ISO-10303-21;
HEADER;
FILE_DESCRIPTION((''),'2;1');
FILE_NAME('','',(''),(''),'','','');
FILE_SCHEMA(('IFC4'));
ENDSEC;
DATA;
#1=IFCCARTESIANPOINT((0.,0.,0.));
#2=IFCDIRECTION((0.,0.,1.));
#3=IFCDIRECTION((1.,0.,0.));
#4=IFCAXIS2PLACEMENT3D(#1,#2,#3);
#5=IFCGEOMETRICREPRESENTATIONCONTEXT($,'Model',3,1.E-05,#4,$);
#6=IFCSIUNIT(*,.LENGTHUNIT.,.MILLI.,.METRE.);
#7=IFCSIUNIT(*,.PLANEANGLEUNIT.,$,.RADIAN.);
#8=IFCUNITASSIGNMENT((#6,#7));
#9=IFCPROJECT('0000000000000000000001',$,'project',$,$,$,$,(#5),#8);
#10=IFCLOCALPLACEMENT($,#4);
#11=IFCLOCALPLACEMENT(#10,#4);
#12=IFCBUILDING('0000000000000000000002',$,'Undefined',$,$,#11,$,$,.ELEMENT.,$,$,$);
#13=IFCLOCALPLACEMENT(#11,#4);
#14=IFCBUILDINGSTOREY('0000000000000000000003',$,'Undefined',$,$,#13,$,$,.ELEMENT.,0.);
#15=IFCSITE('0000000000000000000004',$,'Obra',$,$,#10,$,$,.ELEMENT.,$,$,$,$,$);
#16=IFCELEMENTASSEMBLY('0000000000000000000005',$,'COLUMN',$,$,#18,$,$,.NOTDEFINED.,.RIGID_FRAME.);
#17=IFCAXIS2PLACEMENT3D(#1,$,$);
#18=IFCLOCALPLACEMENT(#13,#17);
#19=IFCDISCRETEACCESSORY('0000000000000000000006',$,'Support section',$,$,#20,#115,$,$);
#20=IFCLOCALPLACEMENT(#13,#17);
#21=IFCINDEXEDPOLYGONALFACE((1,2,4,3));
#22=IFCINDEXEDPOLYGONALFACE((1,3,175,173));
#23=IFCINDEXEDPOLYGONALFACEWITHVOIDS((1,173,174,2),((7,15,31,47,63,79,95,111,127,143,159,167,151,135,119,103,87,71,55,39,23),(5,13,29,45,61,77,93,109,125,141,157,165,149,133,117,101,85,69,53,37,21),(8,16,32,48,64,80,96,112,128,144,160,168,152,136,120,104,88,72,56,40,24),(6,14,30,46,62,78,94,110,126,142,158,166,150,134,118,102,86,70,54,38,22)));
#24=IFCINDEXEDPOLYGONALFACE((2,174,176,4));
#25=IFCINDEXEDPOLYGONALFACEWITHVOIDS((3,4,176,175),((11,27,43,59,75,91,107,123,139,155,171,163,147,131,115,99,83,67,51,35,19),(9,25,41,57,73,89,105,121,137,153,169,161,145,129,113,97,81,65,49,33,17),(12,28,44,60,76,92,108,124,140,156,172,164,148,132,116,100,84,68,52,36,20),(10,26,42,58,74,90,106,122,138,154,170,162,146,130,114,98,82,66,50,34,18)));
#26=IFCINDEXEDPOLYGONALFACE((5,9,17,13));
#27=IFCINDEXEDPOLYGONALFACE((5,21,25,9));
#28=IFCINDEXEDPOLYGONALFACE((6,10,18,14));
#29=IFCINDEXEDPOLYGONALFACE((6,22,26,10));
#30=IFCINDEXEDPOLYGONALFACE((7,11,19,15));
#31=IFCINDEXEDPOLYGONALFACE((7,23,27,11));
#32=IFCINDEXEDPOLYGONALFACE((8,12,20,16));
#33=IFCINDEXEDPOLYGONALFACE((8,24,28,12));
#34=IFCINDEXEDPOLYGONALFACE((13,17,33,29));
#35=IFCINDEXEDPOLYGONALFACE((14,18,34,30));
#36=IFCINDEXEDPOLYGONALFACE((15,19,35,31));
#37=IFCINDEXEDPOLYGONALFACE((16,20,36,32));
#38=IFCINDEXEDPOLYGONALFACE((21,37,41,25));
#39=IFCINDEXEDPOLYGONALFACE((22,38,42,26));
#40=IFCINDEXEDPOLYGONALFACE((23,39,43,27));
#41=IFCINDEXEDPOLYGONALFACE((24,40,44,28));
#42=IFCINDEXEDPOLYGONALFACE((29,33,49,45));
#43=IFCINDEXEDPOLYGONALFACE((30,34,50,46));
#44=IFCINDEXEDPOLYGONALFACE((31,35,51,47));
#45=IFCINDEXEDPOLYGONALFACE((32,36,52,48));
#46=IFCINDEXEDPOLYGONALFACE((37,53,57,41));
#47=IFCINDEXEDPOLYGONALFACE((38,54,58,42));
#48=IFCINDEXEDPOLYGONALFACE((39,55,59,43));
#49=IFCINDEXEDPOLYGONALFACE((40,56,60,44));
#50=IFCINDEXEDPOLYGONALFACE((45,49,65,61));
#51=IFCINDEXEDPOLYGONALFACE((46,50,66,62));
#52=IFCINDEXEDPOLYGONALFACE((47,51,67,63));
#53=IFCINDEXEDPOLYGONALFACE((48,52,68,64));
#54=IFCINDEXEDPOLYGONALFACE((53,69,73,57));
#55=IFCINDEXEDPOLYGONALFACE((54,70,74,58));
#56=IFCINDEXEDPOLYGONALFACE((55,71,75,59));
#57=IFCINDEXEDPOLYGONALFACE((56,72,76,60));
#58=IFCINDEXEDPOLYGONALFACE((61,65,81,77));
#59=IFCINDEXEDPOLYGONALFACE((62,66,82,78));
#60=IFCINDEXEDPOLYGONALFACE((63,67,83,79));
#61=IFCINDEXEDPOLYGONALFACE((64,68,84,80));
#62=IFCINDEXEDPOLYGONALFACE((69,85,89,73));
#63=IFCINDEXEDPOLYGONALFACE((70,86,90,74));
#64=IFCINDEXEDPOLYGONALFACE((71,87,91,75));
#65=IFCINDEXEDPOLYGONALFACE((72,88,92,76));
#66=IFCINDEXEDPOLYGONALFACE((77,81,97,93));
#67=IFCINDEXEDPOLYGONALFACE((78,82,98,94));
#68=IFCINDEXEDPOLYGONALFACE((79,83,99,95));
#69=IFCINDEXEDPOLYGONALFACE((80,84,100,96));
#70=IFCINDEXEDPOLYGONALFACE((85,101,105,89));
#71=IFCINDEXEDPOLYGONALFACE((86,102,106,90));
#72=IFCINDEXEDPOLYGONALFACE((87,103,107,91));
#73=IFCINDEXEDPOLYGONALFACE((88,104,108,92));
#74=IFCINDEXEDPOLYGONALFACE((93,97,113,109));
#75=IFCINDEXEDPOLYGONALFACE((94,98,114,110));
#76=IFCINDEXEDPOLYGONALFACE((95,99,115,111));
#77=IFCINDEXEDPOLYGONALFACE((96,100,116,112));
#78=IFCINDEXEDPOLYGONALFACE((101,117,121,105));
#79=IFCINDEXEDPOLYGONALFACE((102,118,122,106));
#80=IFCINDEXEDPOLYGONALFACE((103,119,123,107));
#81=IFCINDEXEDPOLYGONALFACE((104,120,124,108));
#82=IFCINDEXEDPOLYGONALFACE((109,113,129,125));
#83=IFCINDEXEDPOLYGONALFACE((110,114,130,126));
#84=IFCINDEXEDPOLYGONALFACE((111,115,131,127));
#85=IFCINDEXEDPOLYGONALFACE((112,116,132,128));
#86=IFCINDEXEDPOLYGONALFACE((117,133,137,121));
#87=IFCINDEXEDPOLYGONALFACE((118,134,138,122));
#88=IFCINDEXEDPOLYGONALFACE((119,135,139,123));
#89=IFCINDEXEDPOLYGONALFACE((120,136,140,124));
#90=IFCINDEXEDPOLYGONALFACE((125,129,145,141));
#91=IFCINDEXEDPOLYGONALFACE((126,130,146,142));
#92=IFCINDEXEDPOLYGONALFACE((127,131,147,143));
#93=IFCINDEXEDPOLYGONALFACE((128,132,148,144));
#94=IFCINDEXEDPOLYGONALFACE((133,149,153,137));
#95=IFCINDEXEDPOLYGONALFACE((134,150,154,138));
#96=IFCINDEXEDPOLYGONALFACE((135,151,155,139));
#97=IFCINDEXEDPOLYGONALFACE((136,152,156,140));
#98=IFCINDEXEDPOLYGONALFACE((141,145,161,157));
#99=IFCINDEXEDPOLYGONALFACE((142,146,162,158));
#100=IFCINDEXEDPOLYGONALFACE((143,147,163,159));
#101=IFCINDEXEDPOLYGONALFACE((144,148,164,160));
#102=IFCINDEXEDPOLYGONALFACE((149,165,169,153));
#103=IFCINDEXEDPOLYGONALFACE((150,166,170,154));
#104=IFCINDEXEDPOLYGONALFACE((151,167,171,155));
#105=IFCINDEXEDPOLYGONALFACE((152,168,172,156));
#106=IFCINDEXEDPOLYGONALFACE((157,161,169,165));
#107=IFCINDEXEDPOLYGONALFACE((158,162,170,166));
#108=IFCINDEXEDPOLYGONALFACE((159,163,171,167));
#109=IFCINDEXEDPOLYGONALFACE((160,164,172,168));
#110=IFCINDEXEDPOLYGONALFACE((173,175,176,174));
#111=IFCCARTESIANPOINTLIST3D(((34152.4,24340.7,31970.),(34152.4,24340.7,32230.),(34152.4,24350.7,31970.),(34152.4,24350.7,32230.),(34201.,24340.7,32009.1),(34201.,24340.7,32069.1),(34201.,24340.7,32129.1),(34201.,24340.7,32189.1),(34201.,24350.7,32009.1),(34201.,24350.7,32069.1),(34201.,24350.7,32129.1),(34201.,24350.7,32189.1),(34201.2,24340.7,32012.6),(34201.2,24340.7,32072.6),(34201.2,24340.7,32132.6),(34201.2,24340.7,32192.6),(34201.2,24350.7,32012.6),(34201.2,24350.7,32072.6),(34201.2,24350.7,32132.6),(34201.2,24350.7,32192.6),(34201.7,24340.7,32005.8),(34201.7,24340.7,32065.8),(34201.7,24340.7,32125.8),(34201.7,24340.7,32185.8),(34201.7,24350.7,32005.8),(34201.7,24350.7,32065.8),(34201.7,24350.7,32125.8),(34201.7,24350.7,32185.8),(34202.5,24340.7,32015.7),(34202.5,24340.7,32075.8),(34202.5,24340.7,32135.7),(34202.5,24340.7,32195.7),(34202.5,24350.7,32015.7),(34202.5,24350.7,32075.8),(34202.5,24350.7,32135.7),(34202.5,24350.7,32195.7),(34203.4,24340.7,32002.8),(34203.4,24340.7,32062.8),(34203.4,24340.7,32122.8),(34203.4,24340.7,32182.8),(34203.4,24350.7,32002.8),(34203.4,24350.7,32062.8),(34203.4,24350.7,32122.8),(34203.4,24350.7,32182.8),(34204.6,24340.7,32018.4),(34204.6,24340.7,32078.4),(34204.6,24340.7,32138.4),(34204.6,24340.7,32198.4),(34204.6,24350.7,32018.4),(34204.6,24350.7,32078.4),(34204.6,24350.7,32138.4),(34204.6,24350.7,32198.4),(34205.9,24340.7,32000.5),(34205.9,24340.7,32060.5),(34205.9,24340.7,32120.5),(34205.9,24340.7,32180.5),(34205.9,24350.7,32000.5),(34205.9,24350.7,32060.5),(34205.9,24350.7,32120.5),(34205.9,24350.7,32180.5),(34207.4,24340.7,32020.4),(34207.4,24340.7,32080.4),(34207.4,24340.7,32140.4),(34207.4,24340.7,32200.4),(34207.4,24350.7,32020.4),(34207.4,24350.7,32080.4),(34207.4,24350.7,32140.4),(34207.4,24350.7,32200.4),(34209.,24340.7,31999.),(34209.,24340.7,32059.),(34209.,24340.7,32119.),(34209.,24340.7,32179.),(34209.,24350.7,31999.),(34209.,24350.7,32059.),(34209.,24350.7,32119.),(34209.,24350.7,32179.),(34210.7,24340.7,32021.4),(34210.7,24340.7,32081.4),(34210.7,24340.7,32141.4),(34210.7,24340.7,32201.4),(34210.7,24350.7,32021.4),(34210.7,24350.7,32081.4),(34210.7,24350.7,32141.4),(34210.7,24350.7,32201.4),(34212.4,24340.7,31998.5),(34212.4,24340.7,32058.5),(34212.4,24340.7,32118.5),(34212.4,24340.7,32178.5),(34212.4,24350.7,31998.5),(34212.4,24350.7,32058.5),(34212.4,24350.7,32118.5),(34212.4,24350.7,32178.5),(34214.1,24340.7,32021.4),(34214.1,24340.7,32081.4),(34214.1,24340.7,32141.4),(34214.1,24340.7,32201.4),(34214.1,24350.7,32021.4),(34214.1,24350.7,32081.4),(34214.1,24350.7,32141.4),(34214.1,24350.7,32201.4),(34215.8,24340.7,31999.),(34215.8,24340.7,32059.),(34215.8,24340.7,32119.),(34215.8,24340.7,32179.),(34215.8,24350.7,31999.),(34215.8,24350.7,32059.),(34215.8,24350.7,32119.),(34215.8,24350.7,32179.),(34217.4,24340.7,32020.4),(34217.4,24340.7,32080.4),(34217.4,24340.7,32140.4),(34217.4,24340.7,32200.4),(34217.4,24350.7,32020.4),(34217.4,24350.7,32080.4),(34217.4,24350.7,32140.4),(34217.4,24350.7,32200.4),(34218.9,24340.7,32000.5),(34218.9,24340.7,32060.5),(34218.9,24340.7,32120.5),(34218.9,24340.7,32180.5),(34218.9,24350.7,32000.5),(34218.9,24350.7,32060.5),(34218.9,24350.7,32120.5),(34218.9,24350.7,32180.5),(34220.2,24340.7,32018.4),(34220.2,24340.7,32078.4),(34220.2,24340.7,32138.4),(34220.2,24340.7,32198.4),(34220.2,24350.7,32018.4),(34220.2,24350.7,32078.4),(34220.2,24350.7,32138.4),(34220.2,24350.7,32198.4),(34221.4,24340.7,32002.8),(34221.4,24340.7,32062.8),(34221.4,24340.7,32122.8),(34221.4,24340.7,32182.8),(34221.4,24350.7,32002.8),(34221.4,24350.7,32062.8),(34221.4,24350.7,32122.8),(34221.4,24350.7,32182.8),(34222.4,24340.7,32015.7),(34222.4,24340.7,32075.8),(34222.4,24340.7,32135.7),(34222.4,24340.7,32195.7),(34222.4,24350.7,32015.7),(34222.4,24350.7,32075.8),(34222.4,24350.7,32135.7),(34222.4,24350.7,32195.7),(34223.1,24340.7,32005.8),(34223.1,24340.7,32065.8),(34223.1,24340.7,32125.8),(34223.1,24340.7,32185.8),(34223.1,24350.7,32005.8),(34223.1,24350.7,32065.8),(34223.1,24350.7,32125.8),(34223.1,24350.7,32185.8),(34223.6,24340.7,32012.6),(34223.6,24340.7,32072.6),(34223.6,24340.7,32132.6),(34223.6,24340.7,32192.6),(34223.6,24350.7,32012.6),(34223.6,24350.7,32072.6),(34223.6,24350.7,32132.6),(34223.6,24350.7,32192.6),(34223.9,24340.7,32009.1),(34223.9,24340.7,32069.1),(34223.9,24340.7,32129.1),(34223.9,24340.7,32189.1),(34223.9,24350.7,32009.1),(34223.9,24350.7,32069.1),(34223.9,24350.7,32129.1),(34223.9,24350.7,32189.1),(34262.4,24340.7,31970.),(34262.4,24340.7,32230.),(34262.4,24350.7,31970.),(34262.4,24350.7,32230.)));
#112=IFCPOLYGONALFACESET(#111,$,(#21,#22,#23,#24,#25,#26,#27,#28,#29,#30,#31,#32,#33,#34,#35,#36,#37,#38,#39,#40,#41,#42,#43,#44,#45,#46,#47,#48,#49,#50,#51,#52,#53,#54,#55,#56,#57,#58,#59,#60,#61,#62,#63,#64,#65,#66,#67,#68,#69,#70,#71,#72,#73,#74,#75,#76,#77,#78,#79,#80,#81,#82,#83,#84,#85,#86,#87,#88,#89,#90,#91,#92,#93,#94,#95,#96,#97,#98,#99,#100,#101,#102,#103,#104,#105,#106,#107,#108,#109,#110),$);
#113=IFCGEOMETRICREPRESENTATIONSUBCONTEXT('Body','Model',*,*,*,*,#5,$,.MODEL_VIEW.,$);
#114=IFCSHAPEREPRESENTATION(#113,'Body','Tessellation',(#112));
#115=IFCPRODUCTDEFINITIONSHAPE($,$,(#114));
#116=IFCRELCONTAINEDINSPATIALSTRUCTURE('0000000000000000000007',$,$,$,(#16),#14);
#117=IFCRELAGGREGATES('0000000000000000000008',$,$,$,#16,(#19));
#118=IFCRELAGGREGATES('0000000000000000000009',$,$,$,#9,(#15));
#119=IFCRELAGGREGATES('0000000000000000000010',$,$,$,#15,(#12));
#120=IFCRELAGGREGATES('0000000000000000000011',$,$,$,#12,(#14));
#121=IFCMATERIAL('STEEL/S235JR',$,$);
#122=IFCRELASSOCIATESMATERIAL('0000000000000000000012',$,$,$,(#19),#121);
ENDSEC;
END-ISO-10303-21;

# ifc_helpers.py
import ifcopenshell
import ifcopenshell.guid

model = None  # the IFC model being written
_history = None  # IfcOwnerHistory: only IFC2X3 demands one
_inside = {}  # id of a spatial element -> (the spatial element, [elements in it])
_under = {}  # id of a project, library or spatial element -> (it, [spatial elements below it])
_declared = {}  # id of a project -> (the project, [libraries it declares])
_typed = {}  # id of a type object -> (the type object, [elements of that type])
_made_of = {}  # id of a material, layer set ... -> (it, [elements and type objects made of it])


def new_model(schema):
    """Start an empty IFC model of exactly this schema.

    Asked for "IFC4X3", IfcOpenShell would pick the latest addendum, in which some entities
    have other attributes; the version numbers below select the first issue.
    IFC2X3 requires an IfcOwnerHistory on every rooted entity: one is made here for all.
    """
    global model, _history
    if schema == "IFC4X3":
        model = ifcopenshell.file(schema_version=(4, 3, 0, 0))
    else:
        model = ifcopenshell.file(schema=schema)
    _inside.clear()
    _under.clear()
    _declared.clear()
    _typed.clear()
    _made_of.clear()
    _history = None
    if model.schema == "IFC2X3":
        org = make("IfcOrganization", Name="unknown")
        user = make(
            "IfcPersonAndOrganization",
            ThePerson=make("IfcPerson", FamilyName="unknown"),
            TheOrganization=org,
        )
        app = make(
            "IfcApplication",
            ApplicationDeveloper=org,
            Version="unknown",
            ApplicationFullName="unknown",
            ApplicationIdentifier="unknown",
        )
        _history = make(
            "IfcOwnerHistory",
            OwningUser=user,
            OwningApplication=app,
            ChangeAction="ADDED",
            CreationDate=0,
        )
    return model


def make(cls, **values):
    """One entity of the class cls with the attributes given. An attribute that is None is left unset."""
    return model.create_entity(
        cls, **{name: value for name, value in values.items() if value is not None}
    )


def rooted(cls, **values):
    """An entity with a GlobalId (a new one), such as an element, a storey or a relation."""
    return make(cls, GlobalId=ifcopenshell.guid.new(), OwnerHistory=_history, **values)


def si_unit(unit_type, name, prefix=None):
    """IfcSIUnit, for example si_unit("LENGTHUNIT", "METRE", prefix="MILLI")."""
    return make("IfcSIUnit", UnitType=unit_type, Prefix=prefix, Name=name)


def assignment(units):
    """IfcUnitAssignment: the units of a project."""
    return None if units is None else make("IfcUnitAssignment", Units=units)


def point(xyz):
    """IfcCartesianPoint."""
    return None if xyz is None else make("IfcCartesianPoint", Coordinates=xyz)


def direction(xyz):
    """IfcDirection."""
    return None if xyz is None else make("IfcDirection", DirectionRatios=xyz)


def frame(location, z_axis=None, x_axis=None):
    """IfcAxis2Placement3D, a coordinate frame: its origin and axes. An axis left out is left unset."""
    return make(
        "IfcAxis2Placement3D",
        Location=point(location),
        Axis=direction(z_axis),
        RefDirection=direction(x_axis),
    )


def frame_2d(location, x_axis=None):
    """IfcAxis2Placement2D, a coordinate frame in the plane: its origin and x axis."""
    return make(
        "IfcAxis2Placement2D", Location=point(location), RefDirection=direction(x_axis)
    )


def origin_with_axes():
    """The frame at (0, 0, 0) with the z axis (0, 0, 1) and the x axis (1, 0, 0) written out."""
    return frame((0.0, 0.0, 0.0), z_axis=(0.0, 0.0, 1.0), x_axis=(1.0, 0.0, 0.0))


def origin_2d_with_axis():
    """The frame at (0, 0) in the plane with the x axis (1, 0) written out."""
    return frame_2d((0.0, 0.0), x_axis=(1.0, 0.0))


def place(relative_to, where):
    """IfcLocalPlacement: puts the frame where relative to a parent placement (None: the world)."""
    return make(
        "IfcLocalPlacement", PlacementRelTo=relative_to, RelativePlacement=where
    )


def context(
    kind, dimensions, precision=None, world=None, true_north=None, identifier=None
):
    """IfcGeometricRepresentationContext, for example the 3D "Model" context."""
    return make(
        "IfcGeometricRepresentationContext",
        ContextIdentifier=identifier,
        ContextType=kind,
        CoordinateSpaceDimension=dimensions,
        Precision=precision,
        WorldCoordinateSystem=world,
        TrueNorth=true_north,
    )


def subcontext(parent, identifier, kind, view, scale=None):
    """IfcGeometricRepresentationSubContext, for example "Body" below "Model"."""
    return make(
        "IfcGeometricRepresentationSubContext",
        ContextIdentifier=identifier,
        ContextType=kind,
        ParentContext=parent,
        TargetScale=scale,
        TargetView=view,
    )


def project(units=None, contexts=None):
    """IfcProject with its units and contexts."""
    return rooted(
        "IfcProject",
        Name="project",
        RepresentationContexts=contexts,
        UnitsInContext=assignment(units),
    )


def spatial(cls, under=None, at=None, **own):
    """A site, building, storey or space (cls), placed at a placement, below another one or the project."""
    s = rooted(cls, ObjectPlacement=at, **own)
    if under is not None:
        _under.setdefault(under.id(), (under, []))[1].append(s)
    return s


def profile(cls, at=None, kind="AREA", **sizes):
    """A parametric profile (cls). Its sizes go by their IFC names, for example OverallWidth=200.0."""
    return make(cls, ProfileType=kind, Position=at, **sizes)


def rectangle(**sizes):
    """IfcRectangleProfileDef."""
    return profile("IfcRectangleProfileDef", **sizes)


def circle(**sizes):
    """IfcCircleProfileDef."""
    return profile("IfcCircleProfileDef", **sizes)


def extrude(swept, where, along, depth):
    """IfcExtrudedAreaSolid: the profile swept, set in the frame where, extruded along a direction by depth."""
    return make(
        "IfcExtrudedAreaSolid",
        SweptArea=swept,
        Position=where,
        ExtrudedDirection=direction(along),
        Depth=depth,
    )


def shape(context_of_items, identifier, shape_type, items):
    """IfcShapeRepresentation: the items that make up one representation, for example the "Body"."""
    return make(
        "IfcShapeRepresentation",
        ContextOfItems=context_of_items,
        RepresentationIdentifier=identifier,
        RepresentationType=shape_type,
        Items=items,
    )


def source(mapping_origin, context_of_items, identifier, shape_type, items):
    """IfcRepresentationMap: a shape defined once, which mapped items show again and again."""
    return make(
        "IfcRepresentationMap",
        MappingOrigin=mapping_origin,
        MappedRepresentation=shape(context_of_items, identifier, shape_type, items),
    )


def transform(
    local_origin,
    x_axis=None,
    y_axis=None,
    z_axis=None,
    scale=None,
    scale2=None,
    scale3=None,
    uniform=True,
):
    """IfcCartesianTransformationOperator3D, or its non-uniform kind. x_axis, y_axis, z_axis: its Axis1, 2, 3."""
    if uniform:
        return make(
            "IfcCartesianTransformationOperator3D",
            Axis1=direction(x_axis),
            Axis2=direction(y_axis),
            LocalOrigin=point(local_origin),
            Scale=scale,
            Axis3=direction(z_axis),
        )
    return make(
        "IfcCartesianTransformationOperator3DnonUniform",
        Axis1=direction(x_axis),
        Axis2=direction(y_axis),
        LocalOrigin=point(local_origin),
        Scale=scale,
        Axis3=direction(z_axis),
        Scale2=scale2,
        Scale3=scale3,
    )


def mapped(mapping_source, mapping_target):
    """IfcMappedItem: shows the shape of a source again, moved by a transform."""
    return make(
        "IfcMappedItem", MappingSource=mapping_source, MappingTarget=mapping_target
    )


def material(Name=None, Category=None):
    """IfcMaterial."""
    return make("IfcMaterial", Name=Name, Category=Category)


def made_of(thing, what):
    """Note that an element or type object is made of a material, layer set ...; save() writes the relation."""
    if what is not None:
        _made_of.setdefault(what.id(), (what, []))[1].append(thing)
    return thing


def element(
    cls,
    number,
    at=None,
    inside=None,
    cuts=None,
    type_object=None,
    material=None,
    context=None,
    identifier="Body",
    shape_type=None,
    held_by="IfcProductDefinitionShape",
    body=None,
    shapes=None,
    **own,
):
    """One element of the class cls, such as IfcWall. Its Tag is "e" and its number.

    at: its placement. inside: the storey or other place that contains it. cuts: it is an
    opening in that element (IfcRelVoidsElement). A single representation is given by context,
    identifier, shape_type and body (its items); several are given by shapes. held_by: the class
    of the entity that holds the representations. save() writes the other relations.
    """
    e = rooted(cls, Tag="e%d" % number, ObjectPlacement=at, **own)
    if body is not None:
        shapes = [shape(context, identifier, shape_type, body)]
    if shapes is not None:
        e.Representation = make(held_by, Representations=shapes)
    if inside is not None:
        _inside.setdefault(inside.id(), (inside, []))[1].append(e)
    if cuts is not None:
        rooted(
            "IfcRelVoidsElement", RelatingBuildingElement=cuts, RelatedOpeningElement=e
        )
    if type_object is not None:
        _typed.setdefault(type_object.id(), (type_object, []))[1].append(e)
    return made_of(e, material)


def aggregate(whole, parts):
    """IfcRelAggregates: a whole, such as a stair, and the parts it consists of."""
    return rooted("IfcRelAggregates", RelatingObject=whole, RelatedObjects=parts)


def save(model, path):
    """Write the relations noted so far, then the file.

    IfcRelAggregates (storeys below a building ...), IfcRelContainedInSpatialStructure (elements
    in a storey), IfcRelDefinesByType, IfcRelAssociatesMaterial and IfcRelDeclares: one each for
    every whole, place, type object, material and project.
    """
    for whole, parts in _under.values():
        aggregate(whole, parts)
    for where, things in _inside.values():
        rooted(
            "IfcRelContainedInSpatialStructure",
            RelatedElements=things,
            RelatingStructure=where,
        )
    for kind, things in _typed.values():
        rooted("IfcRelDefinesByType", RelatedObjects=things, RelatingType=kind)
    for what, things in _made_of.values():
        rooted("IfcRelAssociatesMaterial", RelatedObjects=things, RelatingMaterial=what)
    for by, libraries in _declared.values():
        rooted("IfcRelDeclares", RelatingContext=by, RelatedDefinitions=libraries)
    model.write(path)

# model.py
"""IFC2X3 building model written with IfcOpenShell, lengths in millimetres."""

from ifc_helpers import new_model, si_unit, frame, origin_with_axes, origin_2d_with_axis, place, context, subcontext, project, spatial, rectangle, circle, extrude, source, transform, mapped, material, element, aggregate, save


model = new_model("IFC2X3")

# Units and contexts
model_context = context("Model", 3, precision=1e-05, world=origin_with_axes())
body_context = subcontext(model_context, "Body", "Model", "MODEL_VIEW")
ifc_project = project(units=[si_unit("LENGTHUNIT", "METRE", prefix="MILLI"), si_unit("PLANEANGLEUNIT", "RADIAN")], contexts=[model_context])

# Site, building, storey
site_placement = place(None, origin_with_axes())
site = spatial("IfcSite", under=ifc_project, at=site_placement, Name="Obra", CompositionType="ELEMENT")
building_placement = place(site_placement, origin_with_axes())
building = spatial("IfcBuilding", under=site, at=building_placement, Name="Undefined", CompositionType="ELEMENT")
storey_placement = place(building_placement, origin_with_axes())
storey = spatial("IfcBuildingStorey", under=building, at=storey_placement, Name="Undefined", CompositionType="ELEMENT", Elevation=0.0)

# Shared definitions
ifc_material_1 = material(Name="STEEL/S235JR")

# Shared definitions
shared_shape_1 = source(origin_with_axes(), body_context, "Body", "SweptSolid", [
    extrude(circle(Radius=11.5, at=origin_2d_with_axis()), frame((0.0, -14.4, 0.0), z_axis=(0.0, 1.0, 0.0), x_axis=(1.0, 0.0, 0.0)), (0.0, 0.0, 1.0), 10.2),
])

# Element assembly, discrete accessory, opening
assembly_1_placement = place(storey_placement, origin_with_axes())
assembly_1 = element("IfcElementAssembly", 1, at=assembly_1_placement, inside=storey, Name="COLUMN", AssemblyPlace="NOTDEFINED", PredefinedType="RIGID_FRAME")
discrete_accessory_1_placement = place(assembly_1_placement, frame((34207.4, 24345.7, 31970.0), z_axis=(0.0, 0.0, 1.0), x_axis=(-1.0, 0.0, 0.0)))
discrete_accessory_1 = element("IfcDiscreteAccessory", 2, at=discrete_accessory_1_placement, material=ifc_material_1, Name="Support section", context=body_context, shape_type="SweptSolid", body=[
    extrude(rectangle(XDim=10.0, YDim=110.0, at=origin_2d_with_axis()), frame((0.0, 0.0, 260.0), z_axis=(0.0, 0.0, -1.0), x_axis=(0.0, 1.0, 0.0)), (0.0, 0.0, 1.0), 260.0),
])
opening_1_placement = place(assembly_1_placement, frame((34162.4, 24355.0, 32300.0), z_axis=(1.0, 0.0, 0.0), x_axis=(0.0, 0.0, -1.0)))
element("IfcOpeningElement", 3, at=opening_1_placement, cuts=discrete_accessory_1, ObjectType="Opening", context=body_context, shape_type="MappedRepresentation", body=[
    mapped(shared_shape_1, transform((110.0, 0.0, 50.0))),
    mapped(shared_shape_1, transform((170.0, 0.0, 50.0))),
    mapped(shared_shape_1, transform((230.0, 0.0, 50.0))),
    mapped(shared_shape_1, transform((290.0, 0.0, 50.0))),
])
aggregate(assembly_1, [discrete_accessory_1])

save(model, "model.ifc")
